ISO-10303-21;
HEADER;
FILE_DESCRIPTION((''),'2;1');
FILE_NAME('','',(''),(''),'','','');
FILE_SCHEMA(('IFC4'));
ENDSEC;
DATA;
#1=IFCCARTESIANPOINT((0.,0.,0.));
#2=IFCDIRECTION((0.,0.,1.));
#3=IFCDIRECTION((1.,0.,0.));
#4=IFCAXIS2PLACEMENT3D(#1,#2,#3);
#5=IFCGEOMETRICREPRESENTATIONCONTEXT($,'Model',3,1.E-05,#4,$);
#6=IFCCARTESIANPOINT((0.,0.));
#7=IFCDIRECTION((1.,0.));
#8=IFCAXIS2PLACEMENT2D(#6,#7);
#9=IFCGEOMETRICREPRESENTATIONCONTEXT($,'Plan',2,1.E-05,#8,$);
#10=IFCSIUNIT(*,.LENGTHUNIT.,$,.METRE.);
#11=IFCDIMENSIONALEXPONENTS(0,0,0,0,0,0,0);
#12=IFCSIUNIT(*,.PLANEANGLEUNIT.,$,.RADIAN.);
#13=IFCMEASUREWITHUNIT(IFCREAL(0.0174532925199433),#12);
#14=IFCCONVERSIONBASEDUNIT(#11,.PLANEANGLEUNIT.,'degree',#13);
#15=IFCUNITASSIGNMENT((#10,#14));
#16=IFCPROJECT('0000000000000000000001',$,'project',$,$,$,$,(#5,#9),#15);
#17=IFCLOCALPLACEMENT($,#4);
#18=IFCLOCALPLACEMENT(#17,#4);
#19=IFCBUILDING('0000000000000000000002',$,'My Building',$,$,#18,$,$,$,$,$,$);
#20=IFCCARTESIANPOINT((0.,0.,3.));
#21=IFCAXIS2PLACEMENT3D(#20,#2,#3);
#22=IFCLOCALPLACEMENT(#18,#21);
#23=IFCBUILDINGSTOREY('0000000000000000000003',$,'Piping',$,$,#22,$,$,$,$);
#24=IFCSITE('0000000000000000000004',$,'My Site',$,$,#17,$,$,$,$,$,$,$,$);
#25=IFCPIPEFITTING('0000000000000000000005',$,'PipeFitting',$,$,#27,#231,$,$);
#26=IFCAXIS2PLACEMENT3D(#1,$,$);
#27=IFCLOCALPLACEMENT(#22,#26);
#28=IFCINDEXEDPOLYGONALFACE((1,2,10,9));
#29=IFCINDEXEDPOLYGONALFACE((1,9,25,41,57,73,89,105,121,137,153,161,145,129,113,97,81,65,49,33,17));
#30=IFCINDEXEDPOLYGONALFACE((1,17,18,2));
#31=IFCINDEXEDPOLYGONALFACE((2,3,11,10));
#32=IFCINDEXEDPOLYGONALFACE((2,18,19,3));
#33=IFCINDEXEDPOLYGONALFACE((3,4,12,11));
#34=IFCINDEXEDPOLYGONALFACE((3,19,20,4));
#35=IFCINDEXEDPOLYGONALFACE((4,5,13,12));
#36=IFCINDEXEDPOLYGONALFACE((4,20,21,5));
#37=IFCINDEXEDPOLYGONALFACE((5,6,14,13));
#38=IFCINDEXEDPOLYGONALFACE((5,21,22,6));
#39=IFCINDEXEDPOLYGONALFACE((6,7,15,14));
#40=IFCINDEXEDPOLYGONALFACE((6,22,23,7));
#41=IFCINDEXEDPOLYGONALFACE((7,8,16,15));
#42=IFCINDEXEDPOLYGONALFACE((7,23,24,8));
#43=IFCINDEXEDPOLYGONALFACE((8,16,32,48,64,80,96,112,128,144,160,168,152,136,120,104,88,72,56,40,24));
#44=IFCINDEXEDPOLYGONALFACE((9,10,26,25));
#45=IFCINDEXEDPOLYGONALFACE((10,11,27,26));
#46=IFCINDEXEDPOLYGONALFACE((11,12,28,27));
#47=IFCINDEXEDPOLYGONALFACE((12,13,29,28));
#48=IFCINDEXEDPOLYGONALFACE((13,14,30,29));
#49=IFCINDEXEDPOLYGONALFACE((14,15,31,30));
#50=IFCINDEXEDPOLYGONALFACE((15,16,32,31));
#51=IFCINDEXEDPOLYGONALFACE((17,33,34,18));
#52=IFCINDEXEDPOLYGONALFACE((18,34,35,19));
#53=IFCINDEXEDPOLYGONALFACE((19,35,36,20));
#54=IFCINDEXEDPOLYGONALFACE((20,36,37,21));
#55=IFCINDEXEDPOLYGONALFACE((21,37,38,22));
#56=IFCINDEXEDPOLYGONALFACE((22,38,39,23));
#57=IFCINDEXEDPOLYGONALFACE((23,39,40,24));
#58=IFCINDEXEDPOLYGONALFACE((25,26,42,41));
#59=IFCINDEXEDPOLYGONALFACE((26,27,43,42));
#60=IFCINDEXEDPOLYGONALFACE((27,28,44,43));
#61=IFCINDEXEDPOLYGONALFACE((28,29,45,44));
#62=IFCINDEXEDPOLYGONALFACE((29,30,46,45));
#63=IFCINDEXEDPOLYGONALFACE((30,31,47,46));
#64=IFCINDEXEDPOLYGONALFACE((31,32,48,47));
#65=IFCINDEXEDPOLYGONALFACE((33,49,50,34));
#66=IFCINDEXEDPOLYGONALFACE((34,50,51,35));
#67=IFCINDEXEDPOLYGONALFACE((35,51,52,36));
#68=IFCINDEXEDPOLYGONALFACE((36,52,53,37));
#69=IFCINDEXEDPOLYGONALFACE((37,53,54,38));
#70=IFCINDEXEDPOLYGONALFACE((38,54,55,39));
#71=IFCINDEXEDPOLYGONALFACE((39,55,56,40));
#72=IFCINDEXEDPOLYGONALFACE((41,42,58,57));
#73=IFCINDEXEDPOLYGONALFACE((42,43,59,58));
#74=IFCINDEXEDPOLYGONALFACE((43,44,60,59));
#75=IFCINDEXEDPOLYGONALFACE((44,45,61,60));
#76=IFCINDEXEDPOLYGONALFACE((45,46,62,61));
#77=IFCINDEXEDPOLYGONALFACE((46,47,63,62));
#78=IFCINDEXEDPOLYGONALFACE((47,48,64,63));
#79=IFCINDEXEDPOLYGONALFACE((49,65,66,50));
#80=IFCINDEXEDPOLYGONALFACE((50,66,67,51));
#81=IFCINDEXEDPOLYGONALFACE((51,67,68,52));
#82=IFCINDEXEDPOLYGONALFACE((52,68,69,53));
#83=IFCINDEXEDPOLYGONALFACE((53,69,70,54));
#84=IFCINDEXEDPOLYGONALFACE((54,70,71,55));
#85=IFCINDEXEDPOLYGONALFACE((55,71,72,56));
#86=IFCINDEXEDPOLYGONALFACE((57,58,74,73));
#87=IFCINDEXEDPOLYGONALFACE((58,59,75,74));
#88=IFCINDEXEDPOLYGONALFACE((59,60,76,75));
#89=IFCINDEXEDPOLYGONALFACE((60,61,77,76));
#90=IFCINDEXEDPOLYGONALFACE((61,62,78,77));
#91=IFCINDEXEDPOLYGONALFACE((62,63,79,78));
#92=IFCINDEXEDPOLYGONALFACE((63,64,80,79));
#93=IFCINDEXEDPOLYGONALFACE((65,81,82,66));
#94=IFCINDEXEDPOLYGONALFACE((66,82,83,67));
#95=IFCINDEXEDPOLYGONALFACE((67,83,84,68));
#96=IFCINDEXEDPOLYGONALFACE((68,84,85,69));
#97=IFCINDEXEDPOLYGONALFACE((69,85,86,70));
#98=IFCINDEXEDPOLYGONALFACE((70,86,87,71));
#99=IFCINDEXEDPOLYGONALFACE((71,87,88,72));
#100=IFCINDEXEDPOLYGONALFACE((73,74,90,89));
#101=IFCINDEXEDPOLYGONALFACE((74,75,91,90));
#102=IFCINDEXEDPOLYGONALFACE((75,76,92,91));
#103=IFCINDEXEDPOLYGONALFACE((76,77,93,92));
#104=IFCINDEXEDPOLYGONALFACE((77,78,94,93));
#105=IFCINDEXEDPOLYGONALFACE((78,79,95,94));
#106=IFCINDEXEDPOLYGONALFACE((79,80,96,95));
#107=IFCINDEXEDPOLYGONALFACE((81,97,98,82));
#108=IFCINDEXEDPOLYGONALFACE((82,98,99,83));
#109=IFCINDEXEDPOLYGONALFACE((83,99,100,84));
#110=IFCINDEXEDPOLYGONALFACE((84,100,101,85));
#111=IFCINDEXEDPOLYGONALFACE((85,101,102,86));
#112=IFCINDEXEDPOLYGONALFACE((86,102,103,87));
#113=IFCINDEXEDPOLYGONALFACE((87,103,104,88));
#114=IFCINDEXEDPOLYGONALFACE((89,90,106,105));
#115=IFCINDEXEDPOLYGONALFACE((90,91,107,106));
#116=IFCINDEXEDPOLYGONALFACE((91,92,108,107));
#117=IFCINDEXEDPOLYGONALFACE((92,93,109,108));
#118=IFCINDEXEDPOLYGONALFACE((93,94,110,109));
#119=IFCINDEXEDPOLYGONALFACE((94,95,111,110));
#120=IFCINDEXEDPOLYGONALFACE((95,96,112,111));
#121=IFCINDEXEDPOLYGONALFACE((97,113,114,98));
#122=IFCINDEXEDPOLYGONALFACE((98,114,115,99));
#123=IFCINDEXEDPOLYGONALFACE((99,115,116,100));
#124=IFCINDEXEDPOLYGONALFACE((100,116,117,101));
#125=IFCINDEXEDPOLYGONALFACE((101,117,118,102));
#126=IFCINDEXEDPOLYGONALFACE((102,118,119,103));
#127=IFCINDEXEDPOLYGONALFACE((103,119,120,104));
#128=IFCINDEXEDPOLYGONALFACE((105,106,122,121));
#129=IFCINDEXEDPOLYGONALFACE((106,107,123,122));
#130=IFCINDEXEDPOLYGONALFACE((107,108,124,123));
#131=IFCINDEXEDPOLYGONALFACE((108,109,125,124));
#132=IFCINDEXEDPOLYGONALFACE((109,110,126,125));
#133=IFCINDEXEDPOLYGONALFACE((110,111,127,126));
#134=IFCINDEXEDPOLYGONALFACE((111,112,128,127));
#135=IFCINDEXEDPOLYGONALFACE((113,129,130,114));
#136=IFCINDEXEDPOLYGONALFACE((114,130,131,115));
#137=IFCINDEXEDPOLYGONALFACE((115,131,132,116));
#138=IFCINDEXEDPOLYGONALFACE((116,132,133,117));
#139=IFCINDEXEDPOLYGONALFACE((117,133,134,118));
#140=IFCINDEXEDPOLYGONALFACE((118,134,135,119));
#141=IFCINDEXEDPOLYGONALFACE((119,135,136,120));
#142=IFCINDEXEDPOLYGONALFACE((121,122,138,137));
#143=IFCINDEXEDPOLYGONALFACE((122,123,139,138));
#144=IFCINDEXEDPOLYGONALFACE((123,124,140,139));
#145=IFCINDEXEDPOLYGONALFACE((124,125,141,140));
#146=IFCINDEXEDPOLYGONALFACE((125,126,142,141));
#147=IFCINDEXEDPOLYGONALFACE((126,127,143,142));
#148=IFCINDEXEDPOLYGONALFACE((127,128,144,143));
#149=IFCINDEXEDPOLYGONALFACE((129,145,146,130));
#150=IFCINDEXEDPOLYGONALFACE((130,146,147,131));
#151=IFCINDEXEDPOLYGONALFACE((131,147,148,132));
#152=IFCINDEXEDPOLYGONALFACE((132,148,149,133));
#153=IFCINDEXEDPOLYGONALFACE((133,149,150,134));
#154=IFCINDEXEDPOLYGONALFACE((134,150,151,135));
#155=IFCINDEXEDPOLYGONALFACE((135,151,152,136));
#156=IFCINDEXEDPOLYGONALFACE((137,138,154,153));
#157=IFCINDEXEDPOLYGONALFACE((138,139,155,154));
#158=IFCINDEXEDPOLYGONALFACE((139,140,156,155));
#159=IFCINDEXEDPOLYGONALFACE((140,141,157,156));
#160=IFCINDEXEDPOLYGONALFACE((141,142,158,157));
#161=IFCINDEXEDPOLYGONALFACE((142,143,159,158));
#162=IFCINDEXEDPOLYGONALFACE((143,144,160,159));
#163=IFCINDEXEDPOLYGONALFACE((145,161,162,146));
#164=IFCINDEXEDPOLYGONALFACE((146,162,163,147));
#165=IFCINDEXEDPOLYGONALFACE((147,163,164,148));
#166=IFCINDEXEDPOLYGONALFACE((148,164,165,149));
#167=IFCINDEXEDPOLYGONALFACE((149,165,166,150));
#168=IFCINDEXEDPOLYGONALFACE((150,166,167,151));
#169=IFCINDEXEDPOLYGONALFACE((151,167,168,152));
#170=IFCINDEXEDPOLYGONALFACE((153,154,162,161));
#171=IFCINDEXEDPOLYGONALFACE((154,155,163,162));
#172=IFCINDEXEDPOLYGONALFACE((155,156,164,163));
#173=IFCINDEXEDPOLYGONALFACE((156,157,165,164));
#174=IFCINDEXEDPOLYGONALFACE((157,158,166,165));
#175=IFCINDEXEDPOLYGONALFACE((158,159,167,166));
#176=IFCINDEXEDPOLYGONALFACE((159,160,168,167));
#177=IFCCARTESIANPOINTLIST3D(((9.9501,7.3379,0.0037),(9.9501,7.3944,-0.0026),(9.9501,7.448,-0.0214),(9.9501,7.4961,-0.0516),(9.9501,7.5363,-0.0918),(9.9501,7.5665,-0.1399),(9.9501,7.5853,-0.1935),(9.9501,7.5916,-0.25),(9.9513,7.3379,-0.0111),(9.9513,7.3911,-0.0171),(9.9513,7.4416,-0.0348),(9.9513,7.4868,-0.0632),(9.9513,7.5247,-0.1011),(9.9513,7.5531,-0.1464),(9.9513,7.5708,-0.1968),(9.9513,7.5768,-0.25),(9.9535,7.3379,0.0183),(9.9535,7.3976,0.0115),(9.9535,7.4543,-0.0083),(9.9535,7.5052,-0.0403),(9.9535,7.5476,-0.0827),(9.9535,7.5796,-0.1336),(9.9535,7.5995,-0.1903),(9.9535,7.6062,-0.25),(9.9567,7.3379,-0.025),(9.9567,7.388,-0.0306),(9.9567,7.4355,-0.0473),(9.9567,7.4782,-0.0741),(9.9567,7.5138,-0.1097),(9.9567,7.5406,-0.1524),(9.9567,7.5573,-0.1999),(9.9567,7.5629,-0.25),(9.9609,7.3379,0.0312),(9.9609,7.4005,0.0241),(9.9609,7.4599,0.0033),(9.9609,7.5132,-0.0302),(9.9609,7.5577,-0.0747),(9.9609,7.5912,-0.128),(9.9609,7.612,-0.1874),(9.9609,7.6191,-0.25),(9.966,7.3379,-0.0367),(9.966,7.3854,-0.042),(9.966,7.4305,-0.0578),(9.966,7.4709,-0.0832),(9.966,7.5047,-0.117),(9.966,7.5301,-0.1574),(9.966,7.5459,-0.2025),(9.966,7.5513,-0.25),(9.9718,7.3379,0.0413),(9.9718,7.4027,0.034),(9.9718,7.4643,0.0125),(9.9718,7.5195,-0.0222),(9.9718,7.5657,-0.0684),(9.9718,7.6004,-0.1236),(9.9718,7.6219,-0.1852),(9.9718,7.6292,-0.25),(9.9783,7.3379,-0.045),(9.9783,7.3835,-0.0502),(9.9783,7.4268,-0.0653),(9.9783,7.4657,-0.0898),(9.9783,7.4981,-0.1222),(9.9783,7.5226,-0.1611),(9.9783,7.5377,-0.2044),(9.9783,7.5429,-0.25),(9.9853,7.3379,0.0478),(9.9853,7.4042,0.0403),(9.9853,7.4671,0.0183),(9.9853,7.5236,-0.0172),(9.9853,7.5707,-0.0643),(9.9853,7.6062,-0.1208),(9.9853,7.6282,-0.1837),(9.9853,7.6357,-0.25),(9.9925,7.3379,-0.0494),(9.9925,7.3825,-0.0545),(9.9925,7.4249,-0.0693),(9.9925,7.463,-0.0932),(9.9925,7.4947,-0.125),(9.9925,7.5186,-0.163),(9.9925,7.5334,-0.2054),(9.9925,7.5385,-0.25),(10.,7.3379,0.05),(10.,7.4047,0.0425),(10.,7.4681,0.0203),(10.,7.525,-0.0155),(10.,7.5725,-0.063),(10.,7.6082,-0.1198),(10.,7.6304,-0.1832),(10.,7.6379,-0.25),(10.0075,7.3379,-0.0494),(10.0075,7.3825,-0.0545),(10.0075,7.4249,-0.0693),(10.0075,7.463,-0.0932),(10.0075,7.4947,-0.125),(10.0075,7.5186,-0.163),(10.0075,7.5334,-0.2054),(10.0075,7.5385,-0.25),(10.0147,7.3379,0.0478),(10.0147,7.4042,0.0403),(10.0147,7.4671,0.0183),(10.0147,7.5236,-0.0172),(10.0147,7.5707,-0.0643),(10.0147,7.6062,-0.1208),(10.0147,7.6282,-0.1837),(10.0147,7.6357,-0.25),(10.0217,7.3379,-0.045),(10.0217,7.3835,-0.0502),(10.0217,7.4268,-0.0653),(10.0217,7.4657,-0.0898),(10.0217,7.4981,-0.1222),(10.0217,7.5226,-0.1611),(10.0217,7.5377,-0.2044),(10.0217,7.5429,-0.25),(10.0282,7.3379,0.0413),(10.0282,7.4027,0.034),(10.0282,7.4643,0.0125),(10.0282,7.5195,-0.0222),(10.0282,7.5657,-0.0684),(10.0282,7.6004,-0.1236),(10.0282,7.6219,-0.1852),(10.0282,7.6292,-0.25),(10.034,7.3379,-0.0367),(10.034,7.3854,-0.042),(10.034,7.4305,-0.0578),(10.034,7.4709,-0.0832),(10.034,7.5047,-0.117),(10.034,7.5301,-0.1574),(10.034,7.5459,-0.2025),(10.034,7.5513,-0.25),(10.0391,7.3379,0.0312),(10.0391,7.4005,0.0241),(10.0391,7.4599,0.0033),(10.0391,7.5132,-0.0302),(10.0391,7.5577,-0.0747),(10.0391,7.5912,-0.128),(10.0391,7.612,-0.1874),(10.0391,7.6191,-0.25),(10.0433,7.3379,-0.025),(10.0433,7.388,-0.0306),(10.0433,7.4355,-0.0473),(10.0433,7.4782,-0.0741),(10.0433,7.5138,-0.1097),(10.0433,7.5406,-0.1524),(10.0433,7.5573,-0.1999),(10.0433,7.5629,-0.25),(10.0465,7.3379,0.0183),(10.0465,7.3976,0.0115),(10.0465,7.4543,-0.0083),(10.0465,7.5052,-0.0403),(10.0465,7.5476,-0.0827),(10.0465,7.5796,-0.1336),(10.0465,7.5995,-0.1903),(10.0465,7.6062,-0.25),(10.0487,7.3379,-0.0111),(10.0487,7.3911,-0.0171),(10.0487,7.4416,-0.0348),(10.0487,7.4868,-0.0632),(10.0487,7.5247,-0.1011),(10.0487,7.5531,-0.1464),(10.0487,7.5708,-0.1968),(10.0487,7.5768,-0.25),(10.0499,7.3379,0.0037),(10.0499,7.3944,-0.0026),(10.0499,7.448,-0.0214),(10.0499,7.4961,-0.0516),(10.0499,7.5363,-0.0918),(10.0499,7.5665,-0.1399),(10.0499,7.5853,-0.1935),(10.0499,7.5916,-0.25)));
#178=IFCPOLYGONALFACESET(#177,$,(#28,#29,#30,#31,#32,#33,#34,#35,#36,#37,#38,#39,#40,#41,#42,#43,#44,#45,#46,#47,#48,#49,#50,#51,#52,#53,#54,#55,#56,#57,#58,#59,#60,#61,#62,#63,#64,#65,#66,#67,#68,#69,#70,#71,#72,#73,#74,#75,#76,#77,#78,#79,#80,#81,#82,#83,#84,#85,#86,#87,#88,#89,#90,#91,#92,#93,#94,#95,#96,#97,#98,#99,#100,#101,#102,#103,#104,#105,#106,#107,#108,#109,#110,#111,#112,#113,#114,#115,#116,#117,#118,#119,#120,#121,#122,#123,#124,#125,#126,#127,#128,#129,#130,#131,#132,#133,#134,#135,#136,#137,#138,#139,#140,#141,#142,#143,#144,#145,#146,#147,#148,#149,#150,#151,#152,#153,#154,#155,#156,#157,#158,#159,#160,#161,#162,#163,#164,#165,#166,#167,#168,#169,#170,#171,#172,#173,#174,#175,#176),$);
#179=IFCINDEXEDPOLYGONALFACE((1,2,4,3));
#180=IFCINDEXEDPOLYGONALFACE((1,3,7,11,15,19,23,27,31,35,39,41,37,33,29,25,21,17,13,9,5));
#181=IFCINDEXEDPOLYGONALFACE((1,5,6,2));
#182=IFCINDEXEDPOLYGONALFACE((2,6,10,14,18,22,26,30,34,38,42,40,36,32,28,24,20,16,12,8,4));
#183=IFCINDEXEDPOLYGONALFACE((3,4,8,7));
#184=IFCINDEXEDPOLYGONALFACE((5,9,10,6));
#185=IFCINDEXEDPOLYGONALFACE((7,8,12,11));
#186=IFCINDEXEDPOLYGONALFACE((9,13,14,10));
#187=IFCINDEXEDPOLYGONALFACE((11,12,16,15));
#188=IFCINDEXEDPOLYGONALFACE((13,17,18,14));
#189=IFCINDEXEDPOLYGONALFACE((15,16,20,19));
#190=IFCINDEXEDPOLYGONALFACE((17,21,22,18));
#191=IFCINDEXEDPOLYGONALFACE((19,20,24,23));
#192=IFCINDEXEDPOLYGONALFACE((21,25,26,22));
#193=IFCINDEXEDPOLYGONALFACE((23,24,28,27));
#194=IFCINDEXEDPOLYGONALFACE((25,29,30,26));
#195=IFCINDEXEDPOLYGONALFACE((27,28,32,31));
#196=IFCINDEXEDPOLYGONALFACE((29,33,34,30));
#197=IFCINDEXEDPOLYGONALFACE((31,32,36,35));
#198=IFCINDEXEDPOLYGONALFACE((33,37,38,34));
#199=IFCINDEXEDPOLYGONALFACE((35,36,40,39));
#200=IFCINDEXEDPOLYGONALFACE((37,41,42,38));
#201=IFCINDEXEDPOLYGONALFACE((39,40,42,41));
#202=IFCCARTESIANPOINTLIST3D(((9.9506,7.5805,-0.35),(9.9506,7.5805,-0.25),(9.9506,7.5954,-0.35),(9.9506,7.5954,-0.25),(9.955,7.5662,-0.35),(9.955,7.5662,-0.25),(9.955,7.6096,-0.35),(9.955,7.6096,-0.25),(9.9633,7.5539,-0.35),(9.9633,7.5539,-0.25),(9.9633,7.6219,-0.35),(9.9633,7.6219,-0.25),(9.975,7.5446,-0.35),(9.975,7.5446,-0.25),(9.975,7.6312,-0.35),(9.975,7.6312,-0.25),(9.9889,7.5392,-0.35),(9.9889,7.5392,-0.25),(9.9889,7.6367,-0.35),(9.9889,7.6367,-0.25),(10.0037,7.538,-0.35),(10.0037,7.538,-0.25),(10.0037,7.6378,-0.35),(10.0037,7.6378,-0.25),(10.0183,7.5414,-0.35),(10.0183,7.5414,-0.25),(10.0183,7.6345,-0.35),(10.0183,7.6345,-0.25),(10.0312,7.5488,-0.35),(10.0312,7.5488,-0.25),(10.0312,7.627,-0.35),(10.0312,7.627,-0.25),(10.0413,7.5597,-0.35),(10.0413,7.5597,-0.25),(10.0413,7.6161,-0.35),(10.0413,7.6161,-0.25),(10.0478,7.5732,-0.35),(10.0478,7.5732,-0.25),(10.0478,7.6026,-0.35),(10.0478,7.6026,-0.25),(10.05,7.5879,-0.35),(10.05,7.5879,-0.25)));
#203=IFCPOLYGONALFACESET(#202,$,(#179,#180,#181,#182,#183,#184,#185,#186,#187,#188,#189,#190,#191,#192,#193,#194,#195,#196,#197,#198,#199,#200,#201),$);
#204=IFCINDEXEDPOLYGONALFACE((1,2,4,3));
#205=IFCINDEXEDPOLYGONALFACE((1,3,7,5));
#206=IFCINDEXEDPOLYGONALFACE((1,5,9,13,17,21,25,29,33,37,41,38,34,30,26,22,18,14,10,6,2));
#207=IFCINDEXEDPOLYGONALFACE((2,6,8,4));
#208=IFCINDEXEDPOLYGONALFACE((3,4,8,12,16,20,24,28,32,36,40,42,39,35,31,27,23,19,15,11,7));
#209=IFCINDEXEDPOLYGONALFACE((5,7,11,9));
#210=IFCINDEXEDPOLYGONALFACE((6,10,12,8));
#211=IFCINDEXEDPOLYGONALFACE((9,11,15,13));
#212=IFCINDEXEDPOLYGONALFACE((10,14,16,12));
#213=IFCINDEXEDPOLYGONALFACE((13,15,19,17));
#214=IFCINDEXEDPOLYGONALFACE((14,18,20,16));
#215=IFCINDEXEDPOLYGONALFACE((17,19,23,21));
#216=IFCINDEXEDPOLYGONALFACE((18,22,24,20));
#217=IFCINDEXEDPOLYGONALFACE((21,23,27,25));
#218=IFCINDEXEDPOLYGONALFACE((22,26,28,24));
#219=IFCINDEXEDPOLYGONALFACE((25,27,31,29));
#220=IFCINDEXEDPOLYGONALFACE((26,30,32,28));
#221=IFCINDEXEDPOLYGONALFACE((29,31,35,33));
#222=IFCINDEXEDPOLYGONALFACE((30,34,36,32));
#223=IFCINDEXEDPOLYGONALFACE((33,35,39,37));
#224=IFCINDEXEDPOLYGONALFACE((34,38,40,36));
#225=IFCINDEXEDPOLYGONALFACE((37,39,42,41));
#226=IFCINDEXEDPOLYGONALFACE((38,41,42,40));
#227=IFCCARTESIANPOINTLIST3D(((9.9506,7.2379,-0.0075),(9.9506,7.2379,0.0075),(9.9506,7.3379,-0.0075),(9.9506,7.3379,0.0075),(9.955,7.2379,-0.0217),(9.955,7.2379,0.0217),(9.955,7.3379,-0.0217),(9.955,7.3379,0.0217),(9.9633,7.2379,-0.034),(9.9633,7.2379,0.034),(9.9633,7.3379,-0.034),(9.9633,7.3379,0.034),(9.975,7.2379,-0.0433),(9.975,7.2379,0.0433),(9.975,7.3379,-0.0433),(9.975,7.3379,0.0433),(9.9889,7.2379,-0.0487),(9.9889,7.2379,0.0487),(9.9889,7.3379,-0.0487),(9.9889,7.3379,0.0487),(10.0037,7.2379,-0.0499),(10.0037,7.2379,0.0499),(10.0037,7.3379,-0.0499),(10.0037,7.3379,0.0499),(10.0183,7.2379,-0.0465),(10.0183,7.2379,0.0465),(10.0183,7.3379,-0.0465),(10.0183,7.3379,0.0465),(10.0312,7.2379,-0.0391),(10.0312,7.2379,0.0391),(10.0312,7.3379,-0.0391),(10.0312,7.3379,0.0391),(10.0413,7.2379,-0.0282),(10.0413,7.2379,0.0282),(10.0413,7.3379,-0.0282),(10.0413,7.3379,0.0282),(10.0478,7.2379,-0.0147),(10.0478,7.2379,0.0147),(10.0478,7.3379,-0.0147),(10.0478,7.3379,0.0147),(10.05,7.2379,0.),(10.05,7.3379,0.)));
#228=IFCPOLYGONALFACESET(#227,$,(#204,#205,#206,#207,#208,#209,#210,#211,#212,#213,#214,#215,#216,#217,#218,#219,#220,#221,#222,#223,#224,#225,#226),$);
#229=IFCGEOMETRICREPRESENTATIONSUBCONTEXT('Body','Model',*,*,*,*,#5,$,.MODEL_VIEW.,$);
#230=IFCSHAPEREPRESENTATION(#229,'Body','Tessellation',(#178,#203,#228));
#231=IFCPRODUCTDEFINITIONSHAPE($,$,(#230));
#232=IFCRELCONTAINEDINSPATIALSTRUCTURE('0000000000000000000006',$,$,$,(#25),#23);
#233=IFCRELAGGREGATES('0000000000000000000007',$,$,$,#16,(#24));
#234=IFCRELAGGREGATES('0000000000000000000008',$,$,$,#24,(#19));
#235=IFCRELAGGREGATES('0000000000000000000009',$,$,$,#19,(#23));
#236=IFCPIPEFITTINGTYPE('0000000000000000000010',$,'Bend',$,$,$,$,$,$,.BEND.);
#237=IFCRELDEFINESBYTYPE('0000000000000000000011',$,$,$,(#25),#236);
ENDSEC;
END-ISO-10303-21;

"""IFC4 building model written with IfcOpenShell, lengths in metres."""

from ifc_helpers import new_model, entity, si_unit, converted_unit, frame, origin_with_axes, origin_2d_with_axis, place, context, subcontext, project, spatial, line, indexed_curve, circle, outline, extrude, source, transform, mapped, type_object, type_shapes, element, save


model = new_model("IFC4")

# Units and contexts
model_context = context("Model", 3, precision=1e-05, world=origin_with_axes())
plan_context = context("Plan", 2, precision=1e-05, world=origin_2d_with_axis())
body_context = subcontext(model_context, "Body", "Model", "MODEL_VIEW")
ifc_project = project(units=[si_unit("LENGTHUNIT", "METRE"), converted_unit("PLANEANGLEUNIT", "degree", entity("IfcReal", 0.0174532925199433), si_unit("PLANEANGLEUNIT", "RADIAN"), dimensions=[0, 0, 0, 0, 0, 0, 0])], contexts=[model_context, plan_context])

# Site, building, storey
site_placement = place(None, origin_with_axes())
site = spatial("IfcSite", under=ifc_project, at=site_placement, Name="My Site")
building_placement = place(site_placement, origin_with_axes())
building = spatial("IfcBuilding", under=site, at=building_placement, Name="My Building")
storey_placement = place(building_placement, frame((0.0, 0.0, 3.0), z_axis=(0.0, 0.0, 1.0), x_axis=(1.0, 0.0, 0.0)))
storey = spatial("IfcBuildingStorey", under=building, at=storey_placement, Name="Piping")

# Pipe fitting, opening
pipe_fitting_type = type_object("IfcPipeFittingType", Name="Bend", PredefinedType="BEND")
shared_shape = source(origin_with_axes(), body_context, "Body", "SolidModel", [
    entity("IfcSweptDiskSolid", entity("IfcIndexedPolyCurve", entity("IfcCartesianPointList3D", [[0.0, 0.0, -0.1], [0.0, 0.0732, -0.2768], [0.0, 0.25, -0.35]]), [entity("IfcArcIndex", [1, 2, 3])]), 0.05),
    extrude(circle(Radius=0.05), origin_with_axes(), (0.0, 0.0, -1.0), 0.1),
    extrude(circle(Radius=0.05), frame((0.0, 0.25, -0.35), z_axis=(0.0, 1.0, 0.0), x_axis=(1.0, 0.0, 0.0)), (0.0, 0.0, 1.0), 0.1),
])
type_shapes(pipe_fitting_type, [shared_shape])
pipe_fitting_1_placement = place(storey_placement, frame((10.0, 7.5879, -0.35), z_axis=(0.0, 0.0, -1.0), x_axis=(1.0, 0.0, 0.0)))
pipe_fitting_1 = element("IfcPipeFitting", 1, at=pipe_fitting_1_placement, inside=storey, type_object=pipe_fitting_type, Name="PipeFitting", context=body_context, shape_type="MappedRepresentation", body=[
    mapped(shared_shape, transform((0.0, 0.0, 0.0), x_axis=(1.0, 0.0, 0.0), y_axis=(0.0, 1.0, 0.0), z_axis=(0.0, 0.0, 1.0), scale=1.0)),
])
opening_1_placement = place(pipe_fitting_1_placement, frame((1.9673, -1.5235, 2.65), z_axis=(0.0, 0.0, -1.0), x_axis=(-1.0, 0.0, 0.0)))
element("IfcOpeningElement", 2, at=opening_1_placement, cuts=pipe_fitting_1, PredefinedType="OPENING", context=body_context, shape_type="SweptSolid", body=[
    extrude(outline(indexed_curve([(0.0, 0.0), (0.5, 0.0), (0.5, 0.5), (0.0, 0.5)], segments=[line(1, 2, 3, 4, 1)])), origin_with_axes(), (0.0, 0.0, 1.0), 0.5),
])

save(model, "model.ifc")
